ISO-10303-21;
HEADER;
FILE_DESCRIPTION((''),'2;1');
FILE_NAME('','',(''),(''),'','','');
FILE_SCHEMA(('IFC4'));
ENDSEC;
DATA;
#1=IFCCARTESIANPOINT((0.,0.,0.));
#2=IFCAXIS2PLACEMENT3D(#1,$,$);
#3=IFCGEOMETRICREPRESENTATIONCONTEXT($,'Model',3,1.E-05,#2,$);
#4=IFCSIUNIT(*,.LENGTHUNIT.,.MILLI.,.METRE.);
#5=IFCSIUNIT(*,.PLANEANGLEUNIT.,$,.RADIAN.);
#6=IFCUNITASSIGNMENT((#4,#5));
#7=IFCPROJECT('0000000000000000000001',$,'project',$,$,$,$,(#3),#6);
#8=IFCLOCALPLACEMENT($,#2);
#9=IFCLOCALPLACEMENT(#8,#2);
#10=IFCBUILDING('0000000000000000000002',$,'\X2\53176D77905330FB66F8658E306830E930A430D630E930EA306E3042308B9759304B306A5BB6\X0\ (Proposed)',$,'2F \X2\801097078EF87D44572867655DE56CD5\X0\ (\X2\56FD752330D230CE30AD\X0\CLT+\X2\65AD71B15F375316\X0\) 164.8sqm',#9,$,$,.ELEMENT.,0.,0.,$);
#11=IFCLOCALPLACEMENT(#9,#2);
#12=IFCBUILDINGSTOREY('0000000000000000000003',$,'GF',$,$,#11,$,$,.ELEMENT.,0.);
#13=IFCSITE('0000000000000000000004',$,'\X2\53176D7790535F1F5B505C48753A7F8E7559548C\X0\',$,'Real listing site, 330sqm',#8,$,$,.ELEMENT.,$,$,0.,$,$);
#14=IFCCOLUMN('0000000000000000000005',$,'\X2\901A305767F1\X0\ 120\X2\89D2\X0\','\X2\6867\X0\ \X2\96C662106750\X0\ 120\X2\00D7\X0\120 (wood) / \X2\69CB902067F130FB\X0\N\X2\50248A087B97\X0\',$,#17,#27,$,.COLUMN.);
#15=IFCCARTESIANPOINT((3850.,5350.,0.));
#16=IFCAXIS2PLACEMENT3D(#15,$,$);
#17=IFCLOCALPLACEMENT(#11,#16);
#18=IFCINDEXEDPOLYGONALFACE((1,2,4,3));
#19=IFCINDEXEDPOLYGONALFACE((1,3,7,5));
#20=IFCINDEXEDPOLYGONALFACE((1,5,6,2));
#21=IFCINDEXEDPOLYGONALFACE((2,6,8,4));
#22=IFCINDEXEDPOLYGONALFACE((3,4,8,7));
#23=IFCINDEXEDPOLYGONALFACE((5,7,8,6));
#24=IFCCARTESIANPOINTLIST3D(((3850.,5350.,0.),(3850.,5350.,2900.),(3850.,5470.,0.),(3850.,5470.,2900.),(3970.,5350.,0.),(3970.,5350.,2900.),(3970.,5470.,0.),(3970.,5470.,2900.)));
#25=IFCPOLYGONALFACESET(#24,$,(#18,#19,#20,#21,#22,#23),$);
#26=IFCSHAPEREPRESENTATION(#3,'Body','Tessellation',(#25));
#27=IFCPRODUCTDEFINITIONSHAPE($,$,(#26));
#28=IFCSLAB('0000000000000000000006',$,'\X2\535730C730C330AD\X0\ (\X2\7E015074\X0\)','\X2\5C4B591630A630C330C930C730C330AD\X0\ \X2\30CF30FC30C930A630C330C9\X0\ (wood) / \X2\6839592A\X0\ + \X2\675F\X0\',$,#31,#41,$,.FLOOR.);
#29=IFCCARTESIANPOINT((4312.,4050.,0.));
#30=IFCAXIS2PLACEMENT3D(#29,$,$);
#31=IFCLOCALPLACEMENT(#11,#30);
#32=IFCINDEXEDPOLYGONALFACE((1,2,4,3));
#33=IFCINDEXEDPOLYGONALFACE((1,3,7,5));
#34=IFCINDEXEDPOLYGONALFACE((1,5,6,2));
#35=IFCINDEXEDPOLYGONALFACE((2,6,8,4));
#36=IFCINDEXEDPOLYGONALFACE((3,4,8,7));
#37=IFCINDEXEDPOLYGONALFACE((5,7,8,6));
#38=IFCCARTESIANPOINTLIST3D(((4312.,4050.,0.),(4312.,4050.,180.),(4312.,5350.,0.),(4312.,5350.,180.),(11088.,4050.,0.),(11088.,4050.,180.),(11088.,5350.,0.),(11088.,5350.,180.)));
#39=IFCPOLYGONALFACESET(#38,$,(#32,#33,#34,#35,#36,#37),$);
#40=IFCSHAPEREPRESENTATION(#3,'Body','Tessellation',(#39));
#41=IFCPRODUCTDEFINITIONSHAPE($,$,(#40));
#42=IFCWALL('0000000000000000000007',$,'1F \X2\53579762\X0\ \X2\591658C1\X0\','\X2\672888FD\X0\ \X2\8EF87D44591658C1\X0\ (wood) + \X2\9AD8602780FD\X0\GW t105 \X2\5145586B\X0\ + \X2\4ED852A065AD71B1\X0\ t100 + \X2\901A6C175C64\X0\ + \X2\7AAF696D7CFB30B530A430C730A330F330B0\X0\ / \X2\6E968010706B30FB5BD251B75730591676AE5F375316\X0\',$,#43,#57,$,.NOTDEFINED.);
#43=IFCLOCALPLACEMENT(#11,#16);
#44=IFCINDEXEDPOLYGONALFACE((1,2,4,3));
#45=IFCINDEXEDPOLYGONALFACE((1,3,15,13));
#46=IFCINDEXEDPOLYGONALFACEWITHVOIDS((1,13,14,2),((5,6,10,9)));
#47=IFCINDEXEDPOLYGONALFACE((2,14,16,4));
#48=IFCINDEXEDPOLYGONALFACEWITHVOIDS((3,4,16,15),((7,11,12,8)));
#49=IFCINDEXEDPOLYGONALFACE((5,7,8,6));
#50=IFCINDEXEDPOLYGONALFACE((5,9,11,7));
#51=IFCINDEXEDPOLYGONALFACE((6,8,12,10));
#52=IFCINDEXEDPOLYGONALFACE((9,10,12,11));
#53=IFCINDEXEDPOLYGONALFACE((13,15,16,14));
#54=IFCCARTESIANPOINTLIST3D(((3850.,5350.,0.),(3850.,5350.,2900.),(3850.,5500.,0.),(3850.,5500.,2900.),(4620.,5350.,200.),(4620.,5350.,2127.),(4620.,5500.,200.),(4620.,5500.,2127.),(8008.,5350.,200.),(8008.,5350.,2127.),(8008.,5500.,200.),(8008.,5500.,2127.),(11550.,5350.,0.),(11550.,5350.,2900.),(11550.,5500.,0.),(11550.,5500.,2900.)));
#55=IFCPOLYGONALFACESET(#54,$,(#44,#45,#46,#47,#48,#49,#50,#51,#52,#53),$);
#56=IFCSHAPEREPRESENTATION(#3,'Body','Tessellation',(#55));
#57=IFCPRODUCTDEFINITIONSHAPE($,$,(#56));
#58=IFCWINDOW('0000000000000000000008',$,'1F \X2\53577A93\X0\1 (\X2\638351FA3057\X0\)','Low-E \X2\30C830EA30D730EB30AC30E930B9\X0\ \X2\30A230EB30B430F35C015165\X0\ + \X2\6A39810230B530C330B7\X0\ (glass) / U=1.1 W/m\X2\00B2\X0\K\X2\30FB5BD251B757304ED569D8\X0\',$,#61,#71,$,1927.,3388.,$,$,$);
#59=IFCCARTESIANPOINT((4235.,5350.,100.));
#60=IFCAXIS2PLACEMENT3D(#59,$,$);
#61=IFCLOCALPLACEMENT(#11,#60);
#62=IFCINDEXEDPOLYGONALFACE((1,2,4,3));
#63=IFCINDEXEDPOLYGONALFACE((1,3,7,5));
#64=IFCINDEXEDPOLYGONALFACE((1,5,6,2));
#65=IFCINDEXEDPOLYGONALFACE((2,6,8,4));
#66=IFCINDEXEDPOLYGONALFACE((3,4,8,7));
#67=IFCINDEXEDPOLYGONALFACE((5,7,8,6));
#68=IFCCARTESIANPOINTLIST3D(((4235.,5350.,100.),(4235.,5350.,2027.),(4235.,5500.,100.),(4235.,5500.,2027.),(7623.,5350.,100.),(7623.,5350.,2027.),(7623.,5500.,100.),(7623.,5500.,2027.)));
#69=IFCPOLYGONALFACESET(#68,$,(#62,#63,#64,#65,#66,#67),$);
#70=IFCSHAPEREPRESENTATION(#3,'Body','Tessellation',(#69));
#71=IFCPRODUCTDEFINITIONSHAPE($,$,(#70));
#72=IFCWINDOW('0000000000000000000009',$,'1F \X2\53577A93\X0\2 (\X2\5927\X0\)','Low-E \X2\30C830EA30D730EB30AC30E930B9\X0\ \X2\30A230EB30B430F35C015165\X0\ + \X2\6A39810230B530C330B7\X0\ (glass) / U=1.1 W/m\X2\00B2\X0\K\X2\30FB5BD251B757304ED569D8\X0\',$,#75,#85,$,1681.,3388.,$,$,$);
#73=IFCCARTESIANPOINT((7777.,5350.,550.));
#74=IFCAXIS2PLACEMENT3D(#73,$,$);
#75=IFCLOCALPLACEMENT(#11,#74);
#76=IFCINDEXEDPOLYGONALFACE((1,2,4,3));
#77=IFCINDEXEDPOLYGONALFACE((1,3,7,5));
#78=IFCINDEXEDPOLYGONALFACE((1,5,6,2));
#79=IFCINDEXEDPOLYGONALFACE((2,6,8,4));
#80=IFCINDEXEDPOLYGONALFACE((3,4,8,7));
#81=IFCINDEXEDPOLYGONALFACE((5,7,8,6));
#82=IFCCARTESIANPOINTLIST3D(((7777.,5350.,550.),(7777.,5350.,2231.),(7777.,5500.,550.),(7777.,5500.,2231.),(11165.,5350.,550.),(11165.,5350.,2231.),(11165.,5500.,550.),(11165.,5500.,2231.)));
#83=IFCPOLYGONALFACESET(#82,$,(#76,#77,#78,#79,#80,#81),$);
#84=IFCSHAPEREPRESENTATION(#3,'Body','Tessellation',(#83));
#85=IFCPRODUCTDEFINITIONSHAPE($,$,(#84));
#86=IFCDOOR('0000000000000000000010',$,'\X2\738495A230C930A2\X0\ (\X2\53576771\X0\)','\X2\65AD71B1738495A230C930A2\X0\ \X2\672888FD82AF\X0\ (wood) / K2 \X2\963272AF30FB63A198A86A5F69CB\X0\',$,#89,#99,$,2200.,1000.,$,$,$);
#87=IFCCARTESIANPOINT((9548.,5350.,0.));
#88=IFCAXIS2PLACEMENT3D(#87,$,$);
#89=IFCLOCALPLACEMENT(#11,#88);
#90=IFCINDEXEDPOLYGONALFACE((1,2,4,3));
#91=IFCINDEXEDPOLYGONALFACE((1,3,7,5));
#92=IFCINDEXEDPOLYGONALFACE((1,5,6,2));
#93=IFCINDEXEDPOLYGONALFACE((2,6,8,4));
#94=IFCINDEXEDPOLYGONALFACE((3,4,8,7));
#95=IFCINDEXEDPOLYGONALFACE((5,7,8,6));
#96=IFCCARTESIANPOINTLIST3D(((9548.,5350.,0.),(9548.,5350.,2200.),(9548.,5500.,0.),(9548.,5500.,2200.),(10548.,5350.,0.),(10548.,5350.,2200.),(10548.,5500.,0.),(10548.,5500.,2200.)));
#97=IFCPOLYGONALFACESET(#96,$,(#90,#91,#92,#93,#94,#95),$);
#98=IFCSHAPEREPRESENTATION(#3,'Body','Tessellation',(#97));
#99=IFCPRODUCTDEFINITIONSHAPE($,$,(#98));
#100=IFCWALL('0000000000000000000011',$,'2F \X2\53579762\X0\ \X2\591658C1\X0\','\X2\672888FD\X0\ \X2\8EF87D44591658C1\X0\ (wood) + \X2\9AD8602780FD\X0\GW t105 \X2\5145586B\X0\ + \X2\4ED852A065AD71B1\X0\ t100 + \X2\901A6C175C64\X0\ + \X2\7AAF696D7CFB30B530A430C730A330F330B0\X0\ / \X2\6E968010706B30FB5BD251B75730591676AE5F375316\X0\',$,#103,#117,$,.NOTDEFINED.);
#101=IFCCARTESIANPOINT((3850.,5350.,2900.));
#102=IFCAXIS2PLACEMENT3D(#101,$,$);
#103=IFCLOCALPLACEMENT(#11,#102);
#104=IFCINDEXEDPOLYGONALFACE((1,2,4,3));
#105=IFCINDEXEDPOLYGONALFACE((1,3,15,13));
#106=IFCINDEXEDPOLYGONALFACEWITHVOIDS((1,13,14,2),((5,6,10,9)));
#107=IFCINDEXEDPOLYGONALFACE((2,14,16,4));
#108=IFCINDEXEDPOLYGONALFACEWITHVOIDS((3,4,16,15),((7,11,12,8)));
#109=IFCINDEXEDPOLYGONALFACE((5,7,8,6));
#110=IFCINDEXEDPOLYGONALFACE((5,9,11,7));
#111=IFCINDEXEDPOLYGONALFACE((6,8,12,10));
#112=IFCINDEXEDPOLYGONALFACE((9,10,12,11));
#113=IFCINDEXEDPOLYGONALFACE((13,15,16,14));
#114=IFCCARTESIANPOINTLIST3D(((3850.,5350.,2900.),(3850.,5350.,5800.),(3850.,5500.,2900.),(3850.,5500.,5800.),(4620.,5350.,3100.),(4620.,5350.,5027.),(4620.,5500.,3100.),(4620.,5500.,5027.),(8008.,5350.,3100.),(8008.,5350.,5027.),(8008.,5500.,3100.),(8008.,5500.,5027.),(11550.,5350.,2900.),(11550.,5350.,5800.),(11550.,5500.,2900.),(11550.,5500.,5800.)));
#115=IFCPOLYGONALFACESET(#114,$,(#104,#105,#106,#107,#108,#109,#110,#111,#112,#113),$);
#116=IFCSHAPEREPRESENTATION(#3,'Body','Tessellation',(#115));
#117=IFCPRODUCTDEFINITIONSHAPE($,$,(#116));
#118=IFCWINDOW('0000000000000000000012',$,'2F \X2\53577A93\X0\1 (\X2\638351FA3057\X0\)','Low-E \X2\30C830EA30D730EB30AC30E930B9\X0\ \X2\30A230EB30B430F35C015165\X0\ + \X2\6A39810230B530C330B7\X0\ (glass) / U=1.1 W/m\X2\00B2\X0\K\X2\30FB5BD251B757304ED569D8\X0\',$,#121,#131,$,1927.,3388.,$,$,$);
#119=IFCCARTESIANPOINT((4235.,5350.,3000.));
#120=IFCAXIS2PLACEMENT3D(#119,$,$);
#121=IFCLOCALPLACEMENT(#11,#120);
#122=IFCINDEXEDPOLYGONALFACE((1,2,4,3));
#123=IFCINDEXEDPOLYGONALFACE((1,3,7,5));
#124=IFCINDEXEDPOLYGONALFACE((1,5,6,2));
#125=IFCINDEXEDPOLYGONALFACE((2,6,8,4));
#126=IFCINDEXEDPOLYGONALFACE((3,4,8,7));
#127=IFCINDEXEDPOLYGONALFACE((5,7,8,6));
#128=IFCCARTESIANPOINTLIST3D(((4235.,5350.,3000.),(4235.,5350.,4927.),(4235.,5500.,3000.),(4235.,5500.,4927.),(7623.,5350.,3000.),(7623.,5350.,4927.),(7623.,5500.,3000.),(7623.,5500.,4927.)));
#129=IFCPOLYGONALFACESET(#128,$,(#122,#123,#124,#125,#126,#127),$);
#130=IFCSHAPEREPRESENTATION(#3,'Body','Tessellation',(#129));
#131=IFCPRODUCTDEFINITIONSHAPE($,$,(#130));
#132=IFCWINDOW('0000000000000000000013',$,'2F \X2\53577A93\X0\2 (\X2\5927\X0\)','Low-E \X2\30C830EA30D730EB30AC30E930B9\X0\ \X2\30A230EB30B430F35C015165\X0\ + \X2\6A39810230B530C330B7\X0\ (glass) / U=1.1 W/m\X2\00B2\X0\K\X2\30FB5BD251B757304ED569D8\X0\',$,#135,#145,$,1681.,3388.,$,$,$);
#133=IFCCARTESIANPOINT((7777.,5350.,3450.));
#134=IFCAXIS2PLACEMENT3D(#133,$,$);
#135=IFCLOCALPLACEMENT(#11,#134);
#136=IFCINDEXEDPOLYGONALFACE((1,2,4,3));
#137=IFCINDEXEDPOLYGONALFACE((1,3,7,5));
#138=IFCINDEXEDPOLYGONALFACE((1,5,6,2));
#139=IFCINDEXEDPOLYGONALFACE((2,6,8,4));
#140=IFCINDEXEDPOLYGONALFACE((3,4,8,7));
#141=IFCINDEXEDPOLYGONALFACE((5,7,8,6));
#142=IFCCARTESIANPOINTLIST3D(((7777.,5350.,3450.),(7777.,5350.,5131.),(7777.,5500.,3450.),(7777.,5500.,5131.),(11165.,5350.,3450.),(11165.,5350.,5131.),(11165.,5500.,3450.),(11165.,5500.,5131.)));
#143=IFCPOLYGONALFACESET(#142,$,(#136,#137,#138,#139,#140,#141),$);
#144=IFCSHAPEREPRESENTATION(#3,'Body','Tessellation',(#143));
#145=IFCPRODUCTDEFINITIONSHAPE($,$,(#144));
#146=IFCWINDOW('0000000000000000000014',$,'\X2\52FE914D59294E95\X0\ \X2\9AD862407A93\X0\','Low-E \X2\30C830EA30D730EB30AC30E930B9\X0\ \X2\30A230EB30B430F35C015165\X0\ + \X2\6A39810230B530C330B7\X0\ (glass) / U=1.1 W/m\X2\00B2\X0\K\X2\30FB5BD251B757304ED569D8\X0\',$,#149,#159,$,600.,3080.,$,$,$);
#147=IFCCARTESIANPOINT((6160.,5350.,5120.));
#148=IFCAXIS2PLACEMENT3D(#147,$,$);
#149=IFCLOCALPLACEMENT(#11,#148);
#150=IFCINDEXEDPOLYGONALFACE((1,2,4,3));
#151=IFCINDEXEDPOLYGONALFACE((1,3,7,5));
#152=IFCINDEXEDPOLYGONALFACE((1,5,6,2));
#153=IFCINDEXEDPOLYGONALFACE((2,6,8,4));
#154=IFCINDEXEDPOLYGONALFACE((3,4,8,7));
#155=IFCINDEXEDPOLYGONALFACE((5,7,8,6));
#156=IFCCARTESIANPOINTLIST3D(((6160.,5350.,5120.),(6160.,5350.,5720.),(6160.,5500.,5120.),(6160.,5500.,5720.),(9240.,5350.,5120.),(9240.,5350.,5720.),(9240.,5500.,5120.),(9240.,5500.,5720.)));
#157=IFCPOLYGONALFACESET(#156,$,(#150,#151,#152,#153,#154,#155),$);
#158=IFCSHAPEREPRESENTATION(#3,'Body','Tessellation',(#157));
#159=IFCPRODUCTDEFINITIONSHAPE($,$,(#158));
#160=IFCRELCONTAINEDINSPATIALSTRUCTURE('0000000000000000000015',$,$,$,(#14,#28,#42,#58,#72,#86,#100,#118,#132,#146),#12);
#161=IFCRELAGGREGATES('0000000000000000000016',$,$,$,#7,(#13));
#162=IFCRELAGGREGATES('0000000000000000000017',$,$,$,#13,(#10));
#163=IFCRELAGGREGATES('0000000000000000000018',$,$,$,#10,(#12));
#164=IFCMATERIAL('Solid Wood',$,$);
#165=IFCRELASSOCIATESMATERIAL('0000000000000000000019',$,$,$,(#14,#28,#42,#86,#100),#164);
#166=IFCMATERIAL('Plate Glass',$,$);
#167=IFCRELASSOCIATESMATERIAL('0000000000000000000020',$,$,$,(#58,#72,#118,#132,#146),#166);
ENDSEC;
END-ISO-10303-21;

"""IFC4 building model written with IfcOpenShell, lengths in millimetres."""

from ifc_helpers import new_model, si_unit, frame, frame_2d, origin, place, context, project, spatial, rectangle, extrude, material, element, fill, save


model = new_model("IFC4")

# Units and contexts
model_context = context("Model", 3, precision=1e-05, world=origin())
ifc_project = project(units=[si_unit("LENGTHUNIT", "METRE", prefix="MILLI"), si_unit("PLANEANGLEUNIT", "RADIAN")], contexts=[model_context])

# Site, building, storey
site_placement = place(None, origin())
site = spatial("IfcSite", under=ifc_project, at=site_placement, Name="北海道弟子屈町美留和", ObjectType="Real listing site, 330sqm", CompositionType="ELEMENT", RefElevation=0.0)
building_placement = place(site_placement, origin())
building = spatial("IfcBuilding", under=site, at=building_placement, Name="北海道・書斎とライブラリのある静かな家 (Proposed)", ObjectType="2F 耐震軸組在来工法 (国産ヒノキCLT+断熱強化) 164.8sqm", CompositionType="ELEMENT", ElevationOfRefHeight=0.0, ElevationOfTerrain=0.0)
storey_placement = place(building_placement, origin())
storey = spatial("IfcBuildingStorey", under=building, at=storey_placement, Name="GF", CompositionType="ELEMENT", Elevation=0.0)

# Column
ifc_material_1 = material(Name="Solid Wood")
column_placement = place(storey_placement, frame((3850.0, 5350.0, 0.0)))
element("IfcColumn", 1, at=column_placement, inside=storey, material=ifc_material_1, Name="通し柱 120角", Description="桧 集成材 120×120 (wood) / 構造柱・N値計算", PredefinedType="COLUMN", context=model_context, shape_type="SweptSolid", body=[
    extrude(rectangle(XDim=120.0, YDim=120.0, at=frame_2d((60.0, 60.0))), frame((3850.0, 5350.0, 0.0)), (0.0, 0.0, 1.0), 2900.0),
])

# Slab
slab_1_placement = place(storey_placement, frame((4312.0, 4050.0, 0.0)))
element("IfcSlab", 2, at=slab_1_placement, inside=storey, material=ifc_material_1, Name="南デッキ (縁側)", Description="屋外ウッドデッキ ハードウッド (wood) / 根太 + 束", PredefinedType="FLOOR", context=model_context, shape_type="SweptSolid", body=[
    extrude(rectangle(XDim=6776.0, YDim=1300.0, at=frame_2d((3388.0, 650.0))), frame((4312.0, 4050.0, 0.0)), (0.0, 0.0, 1.0), 180.0),
])

# Wall, openings, windows, door
wall_1_placement = place(storey_placement, frame((3850.0, 5350.0, 0.0)))
wall_1 = element("IfcWall", 3, at=wall_1_placement, inside=storey, material=ifc_material_1, Name="1F 南面 外壁", Description="木製 軸組外壁 (wood) + 高性能GW t105 充填 + 付加断熱 t100 + 通気層 + 窯業系サイディング / 準耐火・寒冷地外皮強化", PredefinedType="NOTDEFINED", context=model_context, shape_type="SweptSolid", body=[
    extrude(rectangle(XDim=7700.0, YDim=150.0, at=frame_2d((3850.0, 75.0))), frame((3850.0, 5350.0, 0.0)), (0.0, 0.0, 1.0), 2900.0),
])
opening_1_placement = place(storey_placement, frame((4235.0, 5350.0, 100.0)))
opening_1 = element("IfcOpeningElement", 4, at=opening_1_placement, cuts=wall_1, PredefinedType="NOTDEFINED", context=model_context, shape_type="SweptSolid", body=[
    extrude(rectangle(XDim=3388.0, YDim=150.0, at=frame_2d((1694.0, 75.0))), frame((4235.0, 5350.0, 100.0)), (0.0, 0.0, 1.0), 1927.0),
])
opening_2_placement = place(storey_placement, frame((7777.0, 5350.0, 550.0)))
opening_2 = element("IfcOpeningElement", 5, at=opening_2_placement, cuts=wall_1, PredefinedType="NOTDEFINED", context=model_context, shape_type="SweptSolid", body=[
    extrude(rectangle(XDim=3388.0, YDim=150.0, at=frame_2d((1694.0, 75.0))), frame((7777.0, 5350.0, 550.0)), (0.0, 0.0, 1.0), 1681.0),
])
opening_3_placement = place(storey_placement, frame((9548.0, 5350.0, 0.0)))
opening_3 = element("IfcOpeningElement", 6, at=opening_3_placement, cuts=wall_1, PredefinedType="NOTDEFINED", context=model_context, shape_type="SweptSolid", body=[
    extrude(rectangle(XDim=1000.0, YDim=150.0, at=frame_2d((500.0, 75.0))), frame((9548.0, 5350.0, 0.0)), (0.0, 0.0, 1.0), 2200.0),
])
ifc_material_2 = material(Name="Plate Glass")
window_1_placement = place(storey_placement, frame((4235.0, 5350.0, 100.0)))
window_1 = element("IfcWindow", 7, at=window_1_placement, inside=storey, material=ifc_material_2, Name="1F 南窓1 (掃出し)", Description="Low-E トリプルガラス アルゴン封入 + 樹脂サッシ (glass) / U=1.1 W/m²K・寒冷地仕様", OverallHeight=1927.0, OverallWidth=3388.0, context=model_context, shape_type="SweptSolid", body=[
    extrude(rectangle(XDim=3388.0, YDim=150.0, at=frame_2d((1694.0, 75.0))), frame((4235.0, 5350.0, 100.0)), (0.0, 0.0, 1.0), 1927.0),
])
fill(opening_1, window_1)
window_2_placement = place(storey_placement, frame((7777.0, 5350.0, 550.0)))
window_2 = element("IfcWindow", 8, at=window_2_placement, inside=storey, material=ifc_material_2, Name="1F 南窓2 (大)", Description="Low-E トリプルガラス アルゴン封入 + 樹脂サッシ (glass) / U=1.1 W/m²K・寒冷地仕様", OverallHeight=1681.0, OverallWidth=3388.0, context=model_context, shape_type="SweptSolid", body=[
    extrude(rectangle(XDim=3388.0, YDim=150.0, at=frame_2d((1694.0, 75.0))), frame((7777.0, 5350.0, 550.0)), (0.0, 0.0, 1.0), 1681.0),
])
fill(opening_2, window_2)
door_placement = place(storey_placement, frame((9548.0, 5350.0, 0.0)))
door = element("IfcDoor", 9, at=door_placement, inside=storey, material=ifc_material_1, Name="玄関ドア (南東)", Description="断熱玄関ドア 木製芯 (wood) / K2 防犯・採風機構", OverallHeight=2200.0, OverallWidth=1000.0, context=model_context, shape_type="SweptSolid", body=[
    extrude(rectangle(XDim=1000.0, YDim=150.0, at=frame_2d((500.0, 75.0))), frame((9548.0, 5350.0, 0.0)), (0.0, 0.0, 1.0), 2200.0),
])
fill(opening_3, door)

# Wall, openings, windows
wall_2_placement = place(storey_placement, frame((3850.0, 5350.0, 2900.0)))
wall_2 = element("IfcWall", 10, at=wall_2_placement, inside=storey, material=ifc_material_1, Name="2F 南面 外壁", Description="木製 軸組外壁 (wood) + 高性能GW t105 充填 + 付加断熱 t100 + 通気層 + 窯業系サイディング / 準耐火・寒冷地外皮強化", PredefinedType="NOTDEFINED", context=model_context, shape_type="SweptSolid", body=[
    extrude(rectangle(XDim=7700.0, YDim=150.0, at=frame_2d((3850.0, 75.0))), frame((3850.0, 5350.0, 2900.0)), (0.0, 0.0, 1.0), 2900.0),
])
opening_4_placement = place(storey_placement, frame((4235.0, 5350.0, 3000.0)))
opening_4 = element("IfcOpeningElement", 11, at=opening_4_placement, cuts=wall_2, PredefinedType="NOTDEFINED", context=model_context, shape_type="SweptSolid", body=[
    extrude(rectangle(XDim=3388.0, YDim=150.0, at=frame_2d((1694.0, 75.0))), frame((4235.0, 5350.0, 3000.0)), (0.0, 0.0, 1.0), 1927.0),
])
opening_5_placement = place(storey_placement, frame((7777.0, 5350.0, 3450.0)))
opening_5 = element("IfcOpeningElement", 12, at=opening_5_placement, cuts=wall_2, PredefinedType="NOTDEFINED", context=model_context, shape_type="SweptSolid", body=[
    extrude(rectangle(XDim=3388.0, YDim=150.0, at=frame_2d((1694.0, 75.0))), frame((7777.0, 5350.0, 3450.0)), (0.0, 0.0, 1.0), 1681.0),
])
opening_6_placement = place(storey_placement, frame((6160.0, 5350.0, 5120.0)))
opening_6 = element("IfcOpeningElement", 13, at=opening_6_placement, cuts=wall_2, PredefinedType="NOTDEFINED", context=model_context, shape_type="SweptSolid", body=[
    extrude(rectangle(XDim=3080.0, YDim=150.0, at=frame_2d((1540.0, 75.0))), frame((6160.0, 5350.0, 5120.0)), (0.0, 0.0, 1.0), 600.0),
])
window_3_placement = place(storey_placement, frame((4235.0, 5350.0, 3000.0)))
window_3 = element("IfcWindow", 14, at=window_3_placement, inside=storey, material=ifc_material_2, Name="2F 南窓1 (掃出し)", Description="Low-E トリプルガラス アルゴン封入 + 樹脂サッシ (glass) / U=1.1 W/m²K・寒冷地仕様", OverallHeight=1927.0, OverallWidth=3388.0, context=model_context, shape_type="SweptSolid", body=[
    extrude(rectangle(XDim=3388.0, YDim=150.0, at=frame_2d((1694.0, 75.0))), frame((4235.0, 5350.0, 3000.0)), (0.0, 0.0, 1.0), 1927.0),
])
fill(opening_4, window_3)
window_4_placement = place(storey_placement, frame((7777.0, 5350.0, 3450.0)))
window_4 = element("IfcWindow", 15, at=window_4_placement, inside=storey, material=ifc_material_2, Name="2F 南窓2 (大)", Description="Low-E トリプルガラス アルゴン封入 + 樹脂サッシ (glass) / U=1.1 W/m²K・寒冷地仕様", OverallHeight=1681.0, OverallWidth=3388.0, context=model_context, shape_type="SweptSolid", body=[
    extrude(rectangle(XDim=3388.0, YDim=150.0, at=frame_2d((1694.0, 75.0))), frame((7777.0, 5350.0, 3450.0)), (0.0, 0.0, 1.0), 1681.0),
])
fill(opening_5, window_4)
window_5_placement = place(storey_placement, frame((6160.0, 5350.0, 5120.0)))
window_5 = element("IfcWindow", 16, at=window_5_placement, inside=storey, material=ifc_material_2, Name="勾配天井 高所窓", Description="Low-E トリプルガラス アルゴン封入 + 樹脂サッシ (glass) / U=1.1 W/m²K・寒冷地仕様", OverallHeight=600.0, OverallWidth=3080.0, context=model_context, shape_type="SweptSolid", body=[
    extrude(rectangle(XDim=3080.0, YDim=150.0, at=frame_2d((1540.0, 75.0))), frame((6160.0, 5350.0, 5120.0)), (0.0, 0.0, 1.0), 600.0),
])
fill(opening_6, window_5)

save(model, "model.ifc")
